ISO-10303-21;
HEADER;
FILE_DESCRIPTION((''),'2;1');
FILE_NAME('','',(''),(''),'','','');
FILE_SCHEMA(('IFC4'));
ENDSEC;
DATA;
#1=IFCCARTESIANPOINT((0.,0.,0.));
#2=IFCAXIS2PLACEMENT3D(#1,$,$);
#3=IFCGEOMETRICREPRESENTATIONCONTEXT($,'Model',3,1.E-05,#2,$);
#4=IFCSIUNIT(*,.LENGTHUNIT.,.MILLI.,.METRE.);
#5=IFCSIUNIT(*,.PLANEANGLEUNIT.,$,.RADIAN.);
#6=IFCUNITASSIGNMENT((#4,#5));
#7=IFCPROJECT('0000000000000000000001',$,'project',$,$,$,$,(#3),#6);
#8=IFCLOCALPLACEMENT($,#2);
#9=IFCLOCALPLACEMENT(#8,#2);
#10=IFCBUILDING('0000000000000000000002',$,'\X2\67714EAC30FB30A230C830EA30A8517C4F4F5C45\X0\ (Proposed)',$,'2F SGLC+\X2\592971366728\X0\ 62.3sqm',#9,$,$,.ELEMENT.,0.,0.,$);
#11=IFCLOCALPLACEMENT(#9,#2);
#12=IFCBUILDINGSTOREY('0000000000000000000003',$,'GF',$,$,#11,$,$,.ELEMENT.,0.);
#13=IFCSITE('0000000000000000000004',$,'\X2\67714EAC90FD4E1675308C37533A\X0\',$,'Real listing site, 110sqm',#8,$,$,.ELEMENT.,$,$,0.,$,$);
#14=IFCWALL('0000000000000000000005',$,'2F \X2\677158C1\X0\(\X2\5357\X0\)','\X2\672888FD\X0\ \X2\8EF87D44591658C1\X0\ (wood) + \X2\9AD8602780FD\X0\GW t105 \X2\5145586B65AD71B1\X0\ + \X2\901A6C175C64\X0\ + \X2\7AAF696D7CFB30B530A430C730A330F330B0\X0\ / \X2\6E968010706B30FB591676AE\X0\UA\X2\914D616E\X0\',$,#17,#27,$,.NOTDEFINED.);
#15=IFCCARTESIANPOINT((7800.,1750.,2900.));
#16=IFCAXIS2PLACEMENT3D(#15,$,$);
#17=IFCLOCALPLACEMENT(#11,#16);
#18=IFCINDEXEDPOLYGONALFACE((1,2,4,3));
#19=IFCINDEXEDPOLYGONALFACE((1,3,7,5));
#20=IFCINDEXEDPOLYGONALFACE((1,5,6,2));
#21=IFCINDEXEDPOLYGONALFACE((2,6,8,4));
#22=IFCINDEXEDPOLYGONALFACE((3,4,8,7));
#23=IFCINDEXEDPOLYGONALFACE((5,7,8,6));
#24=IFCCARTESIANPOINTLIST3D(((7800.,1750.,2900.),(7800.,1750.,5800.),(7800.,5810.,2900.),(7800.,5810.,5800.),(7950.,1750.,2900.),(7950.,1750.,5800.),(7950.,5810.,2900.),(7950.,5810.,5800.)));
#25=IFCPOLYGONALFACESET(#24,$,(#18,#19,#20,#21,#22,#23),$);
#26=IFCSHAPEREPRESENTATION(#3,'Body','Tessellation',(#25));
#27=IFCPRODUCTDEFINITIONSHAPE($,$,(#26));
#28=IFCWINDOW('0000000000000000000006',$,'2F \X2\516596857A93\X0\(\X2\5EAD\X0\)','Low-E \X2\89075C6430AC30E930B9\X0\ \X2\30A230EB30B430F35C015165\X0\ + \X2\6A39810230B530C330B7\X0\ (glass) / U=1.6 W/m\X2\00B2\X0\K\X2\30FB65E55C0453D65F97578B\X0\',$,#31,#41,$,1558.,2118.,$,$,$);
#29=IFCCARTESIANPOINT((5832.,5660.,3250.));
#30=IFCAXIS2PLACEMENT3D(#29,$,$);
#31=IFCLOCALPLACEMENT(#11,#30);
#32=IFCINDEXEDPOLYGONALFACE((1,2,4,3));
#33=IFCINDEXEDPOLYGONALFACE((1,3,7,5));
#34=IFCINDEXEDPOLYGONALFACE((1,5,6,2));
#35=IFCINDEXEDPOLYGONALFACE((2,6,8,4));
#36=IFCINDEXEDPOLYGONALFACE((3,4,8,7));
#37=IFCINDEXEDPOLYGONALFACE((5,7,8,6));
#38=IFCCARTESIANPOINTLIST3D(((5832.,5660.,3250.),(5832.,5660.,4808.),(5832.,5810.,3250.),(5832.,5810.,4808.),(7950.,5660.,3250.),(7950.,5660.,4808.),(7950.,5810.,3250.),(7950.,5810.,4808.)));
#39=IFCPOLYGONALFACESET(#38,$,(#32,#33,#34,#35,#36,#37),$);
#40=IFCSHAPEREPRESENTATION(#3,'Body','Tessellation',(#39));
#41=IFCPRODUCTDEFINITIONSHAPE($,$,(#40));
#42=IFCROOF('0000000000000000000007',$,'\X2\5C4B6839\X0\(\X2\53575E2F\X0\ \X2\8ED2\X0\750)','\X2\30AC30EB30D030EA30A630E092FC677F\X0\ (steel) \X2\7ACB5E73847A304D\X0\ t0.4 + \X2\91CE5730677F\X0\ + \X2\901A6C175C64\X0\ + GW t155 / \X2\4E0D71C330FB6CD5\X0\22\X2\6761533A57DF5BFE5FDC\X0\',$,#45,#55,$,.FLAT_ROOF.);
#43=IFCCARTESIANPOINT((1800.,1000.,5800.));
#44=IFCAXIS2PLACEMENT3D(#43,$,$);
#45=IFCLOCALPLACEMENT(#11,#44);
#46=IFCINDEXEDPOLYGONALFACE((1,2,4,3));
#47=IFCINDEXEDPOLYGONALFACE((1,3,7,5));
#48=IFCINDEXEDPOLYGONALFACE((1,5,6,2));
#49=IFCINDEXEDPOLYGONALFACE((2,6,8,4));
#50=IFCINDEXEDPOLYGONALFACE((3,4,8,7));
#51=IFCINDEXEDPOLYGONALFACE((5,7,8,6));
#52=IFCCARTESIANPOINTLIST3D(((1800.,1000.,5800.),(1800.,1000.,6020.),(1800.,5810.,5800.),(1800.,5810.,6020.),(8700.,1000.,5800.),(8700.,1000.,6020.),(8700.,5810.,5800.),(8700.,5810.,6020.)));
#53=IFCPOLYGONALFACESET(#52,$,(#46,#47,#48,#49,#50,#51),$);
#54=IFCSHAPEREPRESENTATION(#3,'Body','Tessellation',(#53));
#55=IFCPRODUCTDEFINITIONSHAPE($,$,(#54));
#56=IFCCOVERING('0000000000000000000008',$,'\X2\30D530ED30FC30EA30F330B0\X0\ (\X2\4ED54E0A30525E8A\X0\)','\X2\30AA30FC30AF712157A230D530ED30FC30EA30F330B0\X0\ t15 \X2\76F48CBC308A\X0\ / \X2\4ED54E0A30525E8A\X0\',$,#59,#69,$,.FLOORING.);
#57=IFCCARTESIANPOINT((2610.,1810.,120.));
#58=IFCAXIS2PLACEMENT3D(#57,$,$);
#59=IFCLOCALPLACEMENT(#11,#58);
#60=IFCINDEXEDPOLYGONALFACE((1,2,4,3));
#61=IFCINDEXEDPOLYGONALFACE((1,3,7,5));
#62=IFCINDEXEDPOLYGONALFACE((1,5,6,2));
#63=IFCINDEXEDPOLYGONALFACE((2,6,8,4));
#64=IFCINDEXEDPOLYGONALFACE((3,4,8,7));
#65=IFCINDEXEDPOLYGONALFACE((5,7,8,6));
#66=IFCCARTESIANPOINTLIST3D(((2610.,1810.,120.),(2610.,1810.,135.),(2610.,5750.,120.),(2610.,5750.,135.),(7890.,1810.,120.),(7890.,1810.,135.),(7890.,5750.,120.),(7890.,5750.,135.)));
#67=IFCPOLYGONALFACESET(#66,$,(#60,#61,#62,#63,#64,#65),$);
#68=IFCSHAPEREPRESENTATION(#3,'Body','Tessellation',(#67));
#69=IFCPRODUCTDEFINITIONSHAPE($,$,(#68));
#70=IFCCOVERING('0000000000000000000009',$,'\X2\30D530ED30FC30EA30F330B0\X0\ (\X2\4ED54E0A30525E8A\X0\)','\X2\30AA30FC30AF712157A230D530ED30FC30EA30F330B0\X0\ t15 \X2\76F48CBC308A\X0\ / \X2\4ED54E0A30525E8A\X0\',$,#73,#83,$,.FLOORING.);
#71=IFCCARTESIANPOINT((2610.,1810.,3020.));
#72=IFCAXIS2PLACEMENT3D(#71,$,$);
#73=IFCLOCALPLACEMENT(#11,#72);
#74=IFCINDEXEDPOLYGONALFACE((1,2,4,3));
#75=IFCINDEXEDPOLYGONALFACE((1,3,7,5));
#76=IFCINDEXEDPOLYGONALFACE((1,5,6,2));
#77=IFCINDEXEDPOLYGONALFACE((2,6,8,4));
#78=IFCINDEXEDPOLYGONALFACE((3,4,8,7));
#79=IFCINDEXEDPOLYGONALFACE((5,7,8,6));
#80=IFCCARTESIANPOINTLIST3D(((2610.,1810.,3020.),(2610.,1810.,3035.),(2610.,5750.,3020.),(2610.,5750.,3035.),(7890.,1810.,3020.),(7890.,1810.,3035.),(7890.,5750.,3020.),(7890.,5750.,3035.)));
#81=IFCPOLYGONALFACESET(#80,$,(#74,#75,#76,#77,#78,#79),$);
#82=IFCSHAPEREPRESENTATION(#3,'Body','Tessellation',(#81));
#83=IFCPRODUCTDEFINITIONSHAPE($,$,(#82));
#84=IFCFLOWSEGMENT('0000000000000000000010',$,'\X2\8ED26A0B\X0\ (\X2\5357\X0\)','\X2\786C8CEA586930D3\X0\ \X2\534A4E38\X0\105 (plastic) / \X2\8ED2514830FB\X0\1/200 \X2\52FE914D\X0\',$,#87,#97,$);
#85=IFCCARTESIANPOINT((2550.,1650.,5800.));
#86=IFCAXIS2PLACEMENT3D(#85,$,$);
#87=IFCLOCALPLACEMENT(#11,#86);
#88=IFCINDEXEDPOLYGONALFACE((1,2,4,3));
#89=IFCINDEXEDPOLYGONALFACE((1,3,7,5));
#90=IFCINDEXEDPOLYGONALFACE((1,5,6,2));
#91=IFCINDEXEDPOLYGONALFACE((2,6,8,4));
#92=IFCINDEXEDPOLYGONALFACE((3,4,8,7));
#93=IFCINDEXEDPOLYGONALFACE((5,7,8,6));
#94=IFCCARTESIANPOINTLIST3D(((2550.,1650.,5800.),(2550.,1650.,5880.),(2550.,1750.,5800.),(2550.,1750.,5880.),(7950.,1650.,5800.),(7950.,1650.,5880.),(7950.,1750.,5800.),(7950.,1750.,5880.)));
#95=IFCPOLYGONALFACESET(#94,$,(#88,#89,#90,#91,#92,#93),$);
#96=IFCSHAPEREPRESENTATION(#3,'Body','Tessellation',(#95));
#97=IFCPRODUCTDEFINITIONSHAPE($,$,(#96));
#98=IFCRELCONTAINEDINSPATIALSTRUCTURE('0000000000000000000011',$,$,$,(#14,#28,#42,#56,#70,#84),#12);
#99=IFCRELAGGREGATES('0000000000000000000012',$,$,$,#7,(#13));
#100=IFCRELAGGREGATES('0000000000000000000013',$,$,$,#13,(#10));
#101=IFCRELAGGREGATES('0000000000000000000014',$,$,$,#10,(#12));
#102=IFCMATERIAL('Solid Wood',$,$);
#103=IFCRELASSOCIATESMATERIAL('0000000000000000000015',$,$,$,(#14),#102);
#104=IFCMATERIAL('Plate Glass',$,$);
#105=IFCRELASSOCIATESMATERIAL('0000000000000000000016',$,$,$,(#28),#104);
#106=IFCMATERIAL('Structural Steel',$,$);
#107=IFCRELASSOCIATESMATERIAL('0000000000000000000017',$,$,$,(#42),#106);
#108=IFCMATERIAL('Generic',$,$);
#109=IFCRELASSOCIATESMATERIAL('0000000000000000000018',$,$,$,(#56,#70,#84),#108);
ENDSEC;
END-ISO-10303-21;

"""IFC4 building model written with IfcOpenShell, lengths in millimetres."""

from ifc_helpers import new_model, si_unit, frame, frame_2d, origin, place, context, project, spatial, rectangle, extrude, material, element, fill, save


model = new_model("IFC4")

# Units and contexts
model_context = context("Model", 3, precision=1e-05, world=origin())
ifc_project = project(units=[si_unit("LENGTHUNIT", "METRE", prefix="MILLI"), si_unit("PLANEANGLEUNIT", "RADIAN")], contexts=[model_context])

# Site, building, storey
site_placement = place(None, origin())
site = spatial("IfcSite", under=ifc_project, at=site_placement, Name="東京都世田谷区", ObjectType="Real listing site, 110sqm", CompositionType="ELEMENT", RefElevation=0.0)
building_placement = place(site_placement, origin())
building = spatial("IfcBuilding", under=site, at=building_placement, Name="東京・アトリエ兼住居 (Proposed)", ObjectType="2F SGLC+天然木 62.3sqm", CompositionType="ELEMENT", ElevationOfRefHeight=0.0, ElevationOfTerrain=0.0)
storey_placement = place(building_placement, origin())
storey = spatial("IfcBuildingStorey", under=building, at=storey_placement, Name="GF", CompositionType="ELEMENT", Elevation=0.0)

# Shared definitions
ifc_material_1 = material(Name="Solid Wood")

# Wall, opening, window
ifc_material_2 = material(Name="Plate Glass")
wall_1_placement = place(storey_placement, frame((7800.0, 1750.0, 2900.0)))
wall_1 = element("IfcWall", 1, at=wall_1_placement, inside=storey, material=ifc_material_1, Name="2F 東壁(南)", Description="木製 軸組外壁 (wood) + 高性能GW t105 充填断熱 + 通気層 + 窯業系サイディング / 準耐火・外皮UA配慮", PredefinedType="NOTDEFINED", context=model_context, shape_type="SweptSolid", body=[
    extrude(rectangle(XDim=150.0, YDim=4060.0, at=frame_2d((75.0, 2030.0))), frame((7800.0, 1750.0, 2900.0)), (0.0, 0.0, 1.0), 2900.0),
])
opening_1_placement = place(storey_placement, frame((5832.0, 5660.0, 3250.0)))
opening_1 = element("IfcOpeningElement", 2, at=opening_1_placement, cuts=wall_1, PredefinedType="NOTDEFINED", context=model_context, shape_type="SweptSolid", body=[
    extrude(rectangle(XDim=2118.0, YDim=150.0, at=frame_2d((1059.0, 75.0))), frame((5832.0, 5660.0, 3250.0)), (0.0, 0.0, 1.0), 1558.0),
])
window_1_placement = place(storey_placement, frame((5832.0, 5660.0, 3250.0)))
window_1 = element("IfcWindow", 3, at=window_1_placement, inside=storey, material=ifc_material_2, Name="2F 入隅窓(庭)", Description="Low-E 複層ガラス アルゴン封入 + 樹脂サッシ (glass) / U=1.6 W/m²K・日射取得型", OverallHeight=1558.0, OverallWidth=2118.0, context=model_context, shape_type="SweptSolid", body=[
    extrude(rectangle(XDim=2118.0, YDim=150.0, at=frame_2d((1059.0, 75.0))), frame((5832.0, 5660.0, 3250.0)), (0.0, 0.0, 1.0), 1558.0),
])
fill(opening_1, window_1)

# Roof
ifc_material_3 = material(Name="Structural Steel")
for number, where, name in (
    (4, (1800.0, 1000.0, 5800.0), "屋根(南帯 軒750)"),
):
    element("IfcRoof", number, at=place(storey_placement, frame(where)), inside=storey, material=ifc_material_3, Name=name, Description="ガルバリウム鋼板 (steel) 立平葺き t0.4 + 野地板 + 通気層 + GW t155 / 不燃・法22条区域対応", PredefinedType="FLAT_ROOF", context=model_context, shape_type="SweptSolid", body=[
        extrude(rectangle(XDim=6900.0, YDim=4810.0, at=frame_2d((3450.0, 2405.0))), frame((1800.0, 1000.0, 5800.0)), (0.0, 0.0, 1.0), 220.0),
    ])

# Coverings
ifc_material_4 = material(Name="Generic")
covering_1_placement = place(storey_placement, frame((2610.0, 1810.0, 120.0)))
element("IfcCovering", 5, at=covering_1_placement, inside=storey, material=ifc_material_4, Name="フローリング (仕上げ床)", Description="オーク無垢フローリング t15 直貼り / 仕上げ床", PredefinedType="FLOORING", context=model_context, shape_type="SweptSolid", body=[
    extrude(rectangle(XDim=5280.0, YDim=3940.0, at=frame_2d((2640.0, 1970.0))), frame((2610.0, 1810.0, 120.0)), (0.0, 0.0, 1.0), 15.0),
])
covering_2_placement = place(storey_placement, frame((2610.0, 1810.0, 3020.0)))
element("IfcCovering", 6, at=covering_2_placement, inside=storey, material=ifc_material_4, Name="フローリング (仕上げ床)", Description="オーク無垢フローリング t15 直貼り / 仕上げ床", PredefinedType="FLOORING", context=model_context, shape_type="SweptSolid", body=[
    extrude(rectangle(XDim=5280.0, YDim=3940.0, at=frame_2d((2640.0, 1970.0))), frame((2610.0, 1810.0, 3020.0)), (0.0, 0.0, 1.0), 15.0),
])

# Flow segment
flow_segment_placement = place(storey_placement, frame((2550.0, 1650.0, 5800.0)))
element("IfcFlowSegment", 7, at=flow_segment_placement, inside=storey, material=ifc_material_4, Name="軒樋 (南)", Description="硬質塩ビ 半丸105 (plastic) / 軒先・1/200 勾配", context=model_context, shape_type="SweptSolid", body=[
    extrude(rectangle(XDim=5400.0, YDim=100.0, at=frame_2d((2700.0, 50.0))), frame((2550.0, 1650.0, 5800.0)), (0.0, 0.0, 1.0), 80.0),
])

save(model, "model.ifc")
